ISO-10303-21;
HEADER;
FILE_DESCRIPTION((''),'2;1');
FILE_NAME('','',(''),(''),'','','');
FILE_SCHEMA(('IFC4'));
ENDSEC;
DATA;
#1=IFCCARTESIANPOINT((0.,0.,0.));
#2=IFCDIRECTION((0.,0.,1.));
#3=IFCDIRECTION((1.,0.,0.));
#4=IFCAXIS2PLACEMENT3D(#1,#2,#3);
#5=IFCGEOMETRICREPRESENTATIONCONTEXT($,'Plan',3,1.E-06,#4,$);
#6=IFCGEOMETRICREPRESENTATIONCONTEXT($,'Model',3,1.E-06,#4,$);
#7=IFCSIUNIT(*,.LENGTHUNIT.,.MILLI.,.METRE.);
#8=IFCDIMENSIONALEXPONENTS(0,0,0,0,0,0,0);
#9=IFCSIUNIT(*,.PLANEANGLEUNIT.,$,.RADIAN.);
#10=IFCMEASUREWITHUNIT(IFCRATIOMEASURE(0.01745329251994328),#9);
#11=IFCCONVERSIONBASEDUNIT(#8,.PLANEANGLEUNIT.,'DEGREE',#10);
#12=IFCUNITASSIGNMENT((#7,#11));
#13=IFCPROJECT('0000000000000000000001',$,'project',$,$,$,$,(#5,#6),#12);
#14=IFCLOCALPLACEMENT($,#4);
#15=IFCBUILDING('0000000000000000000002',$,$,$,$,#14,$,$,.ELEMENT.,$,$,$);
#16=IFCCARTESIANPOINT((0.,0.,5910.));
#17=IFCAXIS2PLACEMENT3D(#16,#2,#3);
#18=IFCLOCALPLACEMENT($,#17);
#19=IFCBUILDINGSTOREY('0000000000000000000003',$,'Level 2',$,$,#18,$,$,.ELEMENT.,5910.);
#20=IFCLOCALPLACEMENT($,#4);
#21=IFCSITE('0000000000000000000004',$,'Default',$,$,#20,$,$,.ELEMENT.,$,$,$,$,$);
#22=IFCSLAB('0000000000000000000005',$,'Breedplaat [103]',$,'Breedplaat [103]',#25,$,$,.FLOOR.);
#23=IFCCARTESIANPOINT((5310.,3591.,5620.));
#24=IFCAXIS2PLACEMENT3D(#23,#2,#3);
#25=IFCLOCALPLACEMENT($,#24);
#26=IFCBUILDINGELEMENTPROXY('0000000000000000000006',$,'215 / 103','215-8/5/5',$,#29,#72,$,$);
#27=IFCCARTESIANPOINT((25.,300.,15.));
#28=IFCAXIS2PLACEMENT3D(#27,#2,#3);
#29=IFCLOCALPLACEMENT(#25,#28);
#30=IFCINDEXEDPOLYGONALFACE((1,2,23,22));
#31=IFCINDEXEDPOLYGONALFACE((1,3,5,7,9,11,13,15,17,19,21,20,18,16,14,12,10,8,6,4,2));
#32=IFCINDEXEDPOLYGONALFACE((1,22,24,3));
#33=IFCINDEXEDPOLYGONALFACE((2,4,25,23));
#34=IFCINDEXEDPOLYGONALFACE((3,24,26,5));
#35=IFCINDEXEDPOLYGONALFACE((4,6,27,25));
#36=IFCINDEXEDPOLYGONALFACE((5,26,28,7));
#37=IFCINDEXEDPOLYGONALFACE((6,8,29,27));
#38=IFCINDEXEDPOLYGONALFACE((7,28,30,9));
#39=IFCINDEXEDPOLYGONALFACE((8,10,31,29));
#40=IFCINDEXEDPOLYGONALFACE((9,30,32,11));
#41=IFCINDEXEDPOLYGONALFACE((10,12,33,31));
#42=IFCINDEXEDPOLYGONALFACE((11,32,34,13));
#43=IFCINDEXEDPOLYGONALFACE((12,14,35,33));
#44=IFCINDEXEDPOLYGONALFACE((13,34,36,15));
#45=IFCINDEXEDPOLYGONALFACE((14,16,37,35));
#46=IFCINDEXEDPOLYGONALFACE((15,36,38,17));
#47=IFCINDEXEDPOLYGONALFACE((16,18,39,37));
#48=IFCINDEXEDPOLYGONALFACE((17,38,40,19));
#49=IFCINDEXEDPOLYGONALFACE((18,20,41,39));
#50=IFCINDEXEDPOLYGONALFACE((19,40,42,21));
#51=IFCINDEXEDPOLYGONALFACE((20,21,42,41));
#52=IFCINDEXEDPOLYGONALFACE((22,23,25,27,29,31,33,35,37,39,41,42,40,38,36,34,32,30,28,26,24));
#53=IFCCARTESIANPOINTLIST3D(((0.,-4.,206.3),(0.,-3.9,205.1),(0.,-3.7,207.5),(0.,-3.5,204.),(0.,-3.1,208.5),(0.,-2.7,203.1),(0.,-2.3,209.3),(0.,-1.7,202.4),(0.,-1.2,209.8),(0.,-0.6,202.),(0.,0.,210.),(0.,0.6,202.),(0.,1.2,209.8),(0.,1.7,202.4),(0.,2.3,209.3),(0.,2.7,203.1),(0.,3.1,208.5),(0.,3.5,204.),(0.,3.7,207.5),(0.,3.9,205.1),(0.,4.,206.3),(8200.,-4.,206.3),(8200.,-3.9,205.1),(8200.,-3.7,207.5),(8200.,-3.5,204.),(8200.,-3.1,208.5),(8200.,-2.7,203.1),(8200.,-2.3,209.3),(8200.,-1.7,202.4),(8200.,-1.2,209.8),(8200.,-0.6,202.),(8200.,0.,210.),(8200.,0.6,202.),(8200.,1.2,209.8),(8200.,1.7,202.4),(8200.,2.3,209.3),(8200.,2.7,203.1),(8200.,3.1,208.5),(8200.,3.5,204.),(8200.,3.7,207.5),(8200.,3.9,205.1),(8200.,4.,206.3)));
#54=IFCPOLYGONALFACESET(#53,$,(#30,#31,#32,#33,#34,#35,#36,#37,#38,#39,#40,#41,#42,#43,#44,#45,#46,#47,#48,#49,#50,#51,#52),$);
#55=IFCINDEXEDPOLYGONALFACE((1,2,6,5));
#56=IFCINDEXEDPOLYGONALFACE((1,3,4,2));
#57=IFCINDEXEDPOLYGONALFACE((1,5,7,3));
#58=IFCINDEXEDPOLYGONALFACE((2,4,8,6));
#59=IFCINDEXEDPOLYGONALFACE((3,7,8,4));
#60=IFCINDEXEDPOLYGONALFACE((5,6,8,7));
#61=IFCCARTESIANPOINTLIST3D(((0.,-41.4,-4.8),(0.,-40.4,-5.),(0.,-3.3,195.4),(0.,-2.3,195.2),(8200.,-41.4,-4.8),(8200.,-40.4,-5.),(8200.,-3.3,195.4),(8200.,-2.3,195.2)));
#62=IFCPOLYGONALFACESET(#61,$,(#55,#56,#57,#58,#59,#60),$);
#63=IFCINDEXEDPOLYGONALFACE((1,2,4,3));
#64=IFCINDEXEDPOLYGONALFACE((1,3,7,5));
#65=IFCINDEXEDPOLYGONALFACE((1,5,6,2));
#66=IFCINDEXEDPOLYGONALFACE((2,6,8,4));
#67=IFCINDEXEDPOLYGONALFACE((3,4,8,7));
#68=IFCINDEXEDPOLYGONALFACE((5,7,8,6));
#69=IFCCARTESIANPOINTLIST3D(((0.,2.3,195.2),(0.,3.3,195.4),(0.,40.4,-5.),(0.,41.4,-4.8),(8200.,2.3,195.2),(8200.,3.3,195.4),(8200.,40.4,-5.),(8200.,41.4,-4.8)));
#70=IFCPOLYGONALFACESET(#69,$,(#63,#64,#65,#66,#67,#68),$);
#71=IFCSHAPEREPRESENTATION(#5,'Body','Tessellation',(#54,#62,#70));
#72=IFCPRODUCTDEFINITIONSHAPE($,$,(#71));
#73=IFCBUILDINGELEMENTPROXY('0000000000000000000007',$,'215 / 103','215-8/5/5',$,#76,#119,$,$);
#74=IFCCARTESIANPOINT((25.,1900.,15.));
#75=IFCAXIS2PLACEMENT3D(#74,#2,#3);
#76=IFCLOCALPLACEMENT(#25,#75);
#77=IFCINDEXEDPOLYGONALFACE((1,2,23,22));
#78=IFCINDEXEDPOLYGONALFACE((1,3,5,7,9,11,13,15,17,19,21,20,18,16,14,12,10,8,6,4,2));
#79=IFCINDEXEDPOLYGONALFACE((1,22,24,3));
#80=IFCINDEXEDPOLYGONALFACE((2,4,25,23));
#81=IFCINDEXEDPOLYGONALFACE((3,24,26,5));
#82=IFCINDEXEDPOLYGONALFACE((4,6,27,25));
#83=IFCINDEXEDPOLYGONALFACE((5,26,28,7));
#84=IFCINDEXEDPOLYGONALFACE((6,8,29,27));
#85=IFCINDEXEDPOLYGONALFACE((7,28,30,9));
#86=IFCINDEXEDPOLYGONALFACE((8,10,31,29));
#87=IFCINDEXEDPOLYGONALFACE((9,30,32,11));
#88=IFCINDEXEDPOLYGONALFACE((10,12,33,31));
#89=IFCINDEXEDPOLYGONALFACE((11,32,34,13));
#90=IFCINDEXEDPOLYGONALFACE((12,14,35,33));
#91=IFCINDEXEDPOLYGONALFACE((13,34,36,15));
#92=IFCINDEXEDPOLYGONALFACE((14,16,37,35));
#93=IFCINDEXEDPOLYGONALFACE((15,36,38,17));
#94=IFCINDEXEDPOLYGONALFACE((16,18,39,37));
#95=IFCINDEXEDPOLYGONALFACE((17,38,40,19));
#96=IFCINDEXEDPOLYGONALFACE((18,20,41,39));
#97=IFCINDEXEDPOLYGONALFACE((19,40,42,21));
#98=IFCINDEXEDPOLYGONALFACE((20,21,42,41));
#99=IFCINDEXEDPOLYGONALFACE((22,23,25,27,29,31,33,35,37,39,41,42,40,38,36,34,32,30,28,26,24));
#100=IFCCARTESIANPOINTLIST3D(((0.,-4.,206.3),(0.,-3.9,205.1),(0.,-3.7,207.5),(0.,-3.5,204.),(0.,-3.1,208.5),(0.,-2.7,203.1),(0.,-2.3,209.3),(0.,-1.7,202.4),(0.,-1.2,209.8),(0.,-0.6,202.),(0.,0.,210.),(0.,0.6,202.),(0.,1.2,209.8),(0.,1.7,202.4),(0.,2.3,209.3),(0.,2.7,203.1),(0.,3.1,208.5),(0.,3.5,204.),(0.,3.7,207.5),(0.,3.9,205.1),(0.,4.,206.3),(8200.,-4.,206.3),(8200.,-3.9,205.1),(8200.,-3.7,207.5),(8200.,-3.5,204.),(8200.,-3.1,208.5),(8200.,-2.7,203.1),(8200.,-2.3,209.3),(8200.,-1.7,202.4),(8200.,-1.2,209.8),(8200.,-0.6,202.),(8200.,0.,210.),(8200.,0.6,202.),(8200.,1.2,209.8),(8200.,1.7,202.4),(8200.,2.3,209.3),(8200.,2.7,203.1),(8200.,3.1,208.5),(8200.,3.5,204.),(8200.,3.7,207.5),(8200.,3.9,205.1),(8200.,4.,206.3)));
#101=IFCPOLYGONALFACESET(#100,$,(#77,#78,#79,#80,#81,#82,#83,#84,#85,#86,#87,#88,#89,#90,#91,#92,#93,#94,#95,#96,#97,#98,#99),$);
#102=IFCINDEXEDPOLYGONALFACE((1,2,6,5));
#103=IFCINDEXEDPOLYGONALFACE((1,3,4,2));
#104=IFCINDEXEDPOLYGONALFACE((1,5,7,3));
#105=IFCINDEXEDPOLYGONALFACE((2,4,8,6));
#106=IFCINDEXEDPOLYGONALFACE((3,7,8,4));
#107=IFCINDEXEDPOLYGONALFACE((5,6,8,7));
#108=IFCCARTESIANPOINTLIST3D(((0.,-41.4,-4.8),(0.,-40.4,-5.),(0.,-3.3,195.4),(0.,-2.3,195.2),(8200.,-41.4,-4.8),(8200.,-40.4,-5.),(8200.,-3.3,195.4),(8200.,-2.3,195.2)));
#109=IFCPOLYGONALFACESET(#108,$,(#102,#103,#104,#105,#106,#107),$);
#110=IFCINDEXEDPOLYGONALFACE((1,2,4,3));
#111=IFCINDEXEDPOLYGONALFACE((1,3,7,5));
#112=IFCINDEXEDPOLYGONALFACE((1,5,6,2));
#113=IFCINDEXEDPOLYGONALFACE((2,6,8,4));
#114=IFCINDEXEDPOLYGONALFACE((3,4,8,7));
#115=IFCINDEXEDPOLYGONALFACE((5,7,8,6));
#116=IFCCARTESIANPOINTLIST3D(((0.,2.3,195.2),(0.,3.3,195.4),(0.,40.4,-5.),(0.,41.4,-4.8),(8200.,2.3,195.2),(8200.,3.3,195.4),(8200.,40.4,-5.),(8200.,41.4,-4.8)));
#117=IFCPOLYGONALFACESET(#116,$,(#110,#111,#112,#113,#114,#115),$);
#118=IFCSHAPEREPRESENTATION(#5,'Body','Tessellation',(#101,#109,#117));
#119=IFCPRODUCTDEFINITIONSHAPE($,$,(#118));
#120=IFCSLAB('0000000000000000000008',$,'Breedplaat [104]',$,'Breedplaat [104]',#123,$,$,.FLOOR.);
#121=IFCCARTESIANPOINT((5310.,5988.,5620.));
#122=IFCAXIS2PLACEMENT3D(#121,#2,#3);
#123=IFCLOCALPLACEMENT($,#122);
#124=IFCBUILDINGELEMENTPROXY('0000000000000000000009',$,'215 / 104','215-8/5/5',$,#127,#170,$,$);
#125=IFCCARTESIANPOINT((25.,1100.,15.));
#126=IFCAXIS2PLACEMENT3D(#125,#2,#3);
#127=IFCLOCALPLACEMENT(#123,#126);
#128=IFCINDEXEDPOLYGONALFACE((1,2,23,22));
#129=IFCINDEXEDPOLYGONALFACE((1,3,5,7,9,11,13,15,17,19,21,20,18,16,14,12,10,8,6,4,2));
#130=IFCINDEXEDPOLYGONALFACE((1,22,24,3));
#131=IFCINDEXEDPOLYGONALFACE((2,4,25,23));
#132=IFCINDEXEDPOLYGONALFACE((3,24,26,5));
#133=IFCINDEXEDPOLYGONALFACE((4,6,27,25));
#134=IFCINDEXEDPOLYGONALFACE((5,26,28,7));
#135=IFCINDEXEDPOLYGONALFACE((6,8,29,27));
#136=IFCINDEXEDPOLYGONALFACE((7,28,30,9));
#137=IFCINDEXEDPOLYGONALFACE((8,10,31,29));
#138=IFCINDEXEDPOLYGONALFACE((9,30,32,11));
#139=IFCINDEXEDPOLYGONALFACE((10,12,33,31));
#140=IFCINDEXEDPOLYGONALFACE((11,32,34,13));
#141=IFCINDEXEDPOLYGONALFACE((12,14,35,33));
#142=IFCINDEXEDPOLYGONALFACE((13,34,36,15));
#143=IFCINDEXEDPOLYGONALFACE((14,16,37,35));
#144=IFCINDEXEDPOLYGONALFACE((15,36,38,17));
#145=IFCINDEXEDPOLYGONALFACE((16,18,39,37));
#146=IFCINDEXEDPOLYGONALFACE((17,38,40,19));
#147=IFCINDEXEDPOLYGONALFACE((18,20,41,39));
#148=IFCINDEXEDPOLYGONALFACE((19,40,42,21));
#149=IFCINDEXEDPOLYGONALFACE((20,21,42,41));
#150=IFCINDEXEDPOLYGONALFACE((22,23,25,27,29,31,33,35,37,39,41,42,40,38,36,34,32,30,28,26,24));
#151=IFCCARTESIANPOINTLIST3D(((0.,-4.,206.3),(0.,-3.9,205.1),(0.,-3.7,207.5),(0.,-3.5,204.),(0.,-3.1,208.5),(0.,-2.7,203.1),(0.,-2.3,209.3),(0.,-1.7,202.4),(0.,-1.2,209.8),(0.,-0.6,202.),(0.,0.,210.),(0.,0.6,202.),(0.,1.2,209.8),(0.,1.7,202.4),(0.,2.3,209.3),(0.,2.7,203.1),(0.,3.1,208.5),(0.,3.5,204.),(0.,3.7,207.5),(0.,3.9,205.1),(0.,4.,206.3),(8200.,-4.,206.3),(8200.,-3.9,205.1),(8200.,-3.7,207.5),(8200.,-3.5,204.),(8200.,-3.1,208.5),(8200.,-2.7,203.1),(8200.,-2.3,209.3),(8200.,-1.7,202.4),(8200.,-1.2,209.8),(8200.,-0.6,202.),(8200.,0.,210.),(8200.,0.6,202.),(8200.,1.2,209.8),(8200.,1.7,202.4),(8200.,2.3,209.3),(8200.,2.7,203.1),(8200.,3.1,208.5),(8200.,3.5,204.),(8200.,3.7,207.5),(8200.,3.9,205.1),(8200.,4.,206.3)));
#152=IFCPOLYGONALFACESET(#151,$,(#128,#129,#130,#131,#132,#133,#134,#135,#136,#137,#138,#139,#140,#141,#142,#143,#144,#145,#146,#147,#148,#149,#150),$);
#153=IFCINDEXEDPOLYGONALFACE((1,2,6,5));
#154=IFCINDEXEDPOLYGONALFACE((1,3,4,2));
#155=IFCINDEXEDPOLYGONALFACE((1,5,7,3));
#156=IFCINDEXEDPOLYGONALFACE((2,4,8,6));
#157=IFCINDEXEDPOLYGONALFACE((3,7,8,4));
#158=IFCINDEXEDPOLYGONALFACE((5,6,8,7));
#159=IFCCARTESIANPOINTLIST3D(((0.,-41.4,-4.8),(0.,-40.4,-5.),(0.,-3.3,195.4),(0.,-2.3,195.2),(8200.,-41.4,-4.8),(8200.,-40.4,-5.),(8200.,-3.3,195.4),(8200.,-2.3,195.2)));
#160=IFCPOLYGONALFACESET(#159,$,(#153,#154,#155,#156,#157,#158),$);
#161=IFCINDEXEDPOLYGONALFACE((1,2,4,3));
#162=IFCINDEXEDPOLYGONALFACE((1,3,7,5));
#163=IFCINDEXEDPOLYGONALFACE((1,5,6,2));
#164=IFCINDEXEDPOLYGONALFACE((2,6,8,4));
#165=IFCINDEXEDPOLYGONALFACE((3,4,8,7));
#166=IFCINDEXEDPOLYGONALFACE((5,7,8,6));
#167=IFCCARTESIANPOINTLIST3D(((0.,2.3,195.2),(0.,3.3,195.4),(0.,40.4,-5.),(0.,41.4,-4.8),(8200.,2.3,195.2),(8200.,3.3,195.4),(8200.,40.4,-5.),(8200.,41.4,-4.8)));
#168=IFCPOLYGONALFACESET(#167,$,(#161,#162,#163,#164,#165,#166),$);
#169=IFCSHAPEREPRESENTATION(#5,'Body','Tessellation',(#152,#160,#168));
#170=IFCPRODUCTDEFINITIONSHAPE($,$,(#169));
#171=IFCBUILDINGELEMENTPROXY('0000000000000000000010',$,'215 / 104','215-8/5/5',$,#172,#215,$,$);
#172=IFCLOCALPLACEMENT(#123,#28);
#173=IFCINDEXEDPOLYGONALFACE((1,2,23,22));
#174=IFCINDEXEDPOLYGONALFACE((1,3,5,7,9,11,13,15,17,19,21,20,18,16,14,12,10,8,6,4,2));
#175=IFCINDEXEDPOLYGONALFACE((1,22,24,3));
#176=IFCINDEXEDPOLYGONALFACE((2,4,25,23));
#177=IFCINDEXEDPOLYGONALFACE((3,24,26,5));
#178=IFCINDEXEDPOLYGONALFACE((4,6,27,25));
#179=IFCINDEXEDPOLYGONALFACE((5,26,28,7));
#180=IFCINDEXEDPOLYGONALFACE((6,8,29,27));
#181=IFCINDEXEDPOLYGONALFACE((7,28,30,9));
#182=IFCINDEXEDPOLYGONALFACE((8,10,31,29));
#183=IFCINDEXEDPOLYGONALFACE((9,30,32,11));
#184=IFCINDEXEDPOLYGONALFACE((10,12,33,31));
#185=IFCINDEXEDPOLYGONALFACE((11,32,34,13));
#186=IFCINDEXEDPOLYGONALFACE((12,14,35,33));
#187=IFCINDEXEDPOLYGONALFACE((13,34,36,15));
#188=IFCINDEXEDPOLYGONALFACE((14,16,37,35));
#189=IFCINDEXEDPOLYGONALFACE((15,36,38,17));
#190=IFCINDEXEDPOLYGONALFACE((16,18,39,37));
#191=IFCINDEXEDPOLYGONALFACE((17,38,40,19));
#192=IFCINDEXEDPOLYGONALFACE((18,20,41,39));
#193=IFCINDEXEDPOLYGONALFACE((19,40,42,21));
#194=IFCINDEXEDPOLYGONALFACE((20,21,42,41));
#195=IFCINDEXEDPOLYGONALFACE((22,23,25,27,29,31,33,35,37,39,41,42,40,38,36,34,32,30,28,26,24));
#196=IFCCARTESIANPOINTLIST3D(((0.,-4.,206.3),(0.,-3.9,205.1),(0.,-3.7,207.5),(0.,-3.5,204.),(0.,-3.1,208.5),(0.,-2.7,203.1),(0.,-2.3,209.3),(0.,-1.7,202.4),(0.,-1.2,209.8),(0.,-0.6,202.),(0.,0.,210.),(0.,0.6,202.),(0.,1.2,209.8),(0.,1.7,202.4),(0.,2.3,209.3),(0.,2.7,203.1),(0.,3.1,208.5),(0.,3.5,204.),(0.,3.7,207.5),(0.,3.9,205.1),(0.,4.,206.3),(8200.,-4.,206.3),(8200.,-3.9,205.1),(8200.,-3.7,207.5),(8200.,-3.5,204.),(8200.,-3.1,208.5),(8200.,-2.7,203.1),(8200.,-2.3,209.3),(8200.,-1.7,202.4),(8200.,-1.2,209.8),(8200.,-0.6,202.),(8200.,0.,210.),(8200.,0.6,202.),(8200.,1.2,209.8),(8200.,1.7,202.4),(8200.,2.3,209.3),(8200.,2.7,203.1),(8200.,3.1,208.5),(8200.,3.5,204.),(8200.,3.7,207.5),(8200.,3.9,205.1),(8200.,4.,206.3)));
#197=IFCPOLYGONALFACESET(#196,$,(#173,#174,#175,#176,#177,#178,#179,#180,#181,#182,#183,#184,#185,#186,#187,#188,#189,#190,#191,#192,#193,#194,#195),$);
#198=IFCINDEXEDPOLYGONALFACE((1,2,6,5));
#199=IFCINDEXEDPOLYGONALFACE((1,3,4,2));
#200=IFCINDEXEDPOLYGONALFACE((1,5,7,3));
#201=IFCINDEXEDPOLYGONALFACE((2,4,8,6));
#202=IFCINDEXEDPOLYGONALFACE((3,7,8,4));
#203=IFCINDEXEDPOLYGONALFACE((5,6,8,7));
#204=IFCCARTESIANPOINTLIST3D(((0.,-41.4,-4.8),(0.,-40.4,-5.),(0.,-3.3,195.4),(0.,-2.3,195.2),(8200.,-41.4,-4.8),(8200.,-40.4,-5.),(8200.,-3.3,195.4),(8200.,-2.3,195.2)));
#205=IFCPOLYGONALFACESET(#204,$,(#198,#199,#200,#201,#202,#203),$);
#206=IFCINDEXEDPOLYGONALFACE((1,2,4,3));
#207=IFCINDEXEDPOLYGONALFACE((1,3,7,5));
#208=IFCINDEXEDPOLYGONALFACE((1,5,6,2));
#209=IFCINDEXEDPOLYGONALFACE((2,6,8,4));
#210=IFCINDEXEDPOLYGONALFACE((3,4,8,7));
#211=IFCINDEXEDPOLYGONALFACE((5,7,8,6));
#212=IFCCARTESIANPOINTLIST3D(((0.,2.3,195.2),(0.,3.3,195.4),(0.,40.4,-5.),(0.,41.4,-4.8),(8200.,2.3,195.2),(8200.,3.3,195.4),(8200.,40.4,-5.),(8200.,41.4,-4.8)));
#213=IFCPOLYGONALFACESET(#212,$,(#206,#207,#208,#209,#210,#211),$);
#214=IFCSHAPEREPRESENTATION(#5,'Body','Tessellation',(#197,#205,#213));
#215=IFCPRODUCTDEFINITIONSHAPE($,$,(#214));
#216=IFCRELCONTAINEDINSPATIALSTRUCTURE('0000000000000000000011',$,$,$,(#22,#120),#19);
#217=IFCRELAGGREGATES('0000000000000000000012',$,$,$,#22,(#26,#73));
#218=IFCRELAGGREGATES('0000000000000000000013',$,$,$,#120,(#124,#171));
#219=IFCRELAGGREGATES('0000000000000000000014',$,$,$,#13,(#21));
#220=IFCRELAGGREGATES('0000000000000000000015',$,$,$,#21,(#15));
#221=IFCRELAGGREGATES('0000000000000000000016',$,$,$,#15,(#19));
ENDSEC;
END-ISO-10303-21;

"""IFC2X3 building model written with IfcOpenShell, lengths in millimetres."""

from ifc_helpers import new_model, entity, si_unit, converted_unit, frame, origin_with_axes, origin_2d_with_axis, place, context, project, spatial, rectangle, circle, extrude, element, aggregate, save


model = new_model("IFC2X3")

# Units and contexts
plan_context = context("Plan", 3, precision=1e-06, world=origin_with_axes())
model_context = context("Model", 3, precision=1e-06, world=origin_with_axes())
ifc_project = project(units=[si_unit("LENGTHUNIT", "METRE", prefix="MILLI"), converted_unit("PLANEANGLEUNIT", "DEGREE", entity("IfcRatioMeasure", 0.01745329251994328), si_unit("PLANEANGLEUNIT", "RADIAN"), dimensions=[0, 0, 0, 0, 0, 0, 0])], contexts=[plan_context, model_context])

# Site, building, storey
site_placement = place(None, origin_with_axes())
site = spatial("IfcSite", under=ifc_project, at=site_placement, Name="Default", CompositionType="ELEMENT")
building_placement = place(None, origin_with_axes())
building = spatial("IfcBuilding", under=site, at=building_placement, CompositionType="ELEMENT")
storey_placement = place(None, frame((0.0, 0.0, 5910.0), z_axis=(0.0, 0.0, 1.0), x_axis=(1.0, 0.0, 0.0)))
storey = spatial("IfcBuildingStorey", under=building, at=storey_placement, Name="Level 2", CompositionType="ELEMENT", Elevation=5910.0)

# Slabs, building element proxies
slab_1_placement = place(None, frame((5310.0, 3591.0, 5620.0), z_axis=(0.0, 0.0, 1.0), x_axis=(1.0, 0.0, 0.0)))
slab_1 = element("IfcSlab", 1, at=slab_1_placement, inside=storey, Name="Breedplaat [103]", ObjectType="Breedplaat [103]", PredefinedType="FLOOR")
proxy_1_placement = place(slab_1_placement, frame((25.0, 300.0, 15.0), z_axis=(0.0, 0.0, 1.0), x_axis=(1.0, 0.0, 0.0)))
proxy_1 = element("IfcBuildingElementProxy", 2, at=proxy_1_placement, Name="215 / 103", Description="215-8/5/5", context=plan_context, shape_type="SweptSolid", body=[
    extrude(circle(Radius=4.0, at=origin_2d_with_axis()), frame((0.0, 0.0, 206.0), z_axis=(1.0, 0.0, 0.0), x_axis=(0.0, 0.0, 1.0)), (0.0, 0.0, 1.0), 8200.0),
    extrude(rectangle(XDim=203.8, YDim=1.0, at=origin_2d_with_axis()), frame((0.0, -21.9, 95.2), z_axis=(1.0, 0.0, 0.0), x_axis=(0.0, 0.187112, 0.982339)), (0.0, 0.0, 1.0), 8200.0),
    extrude(rectangle(XDim=203.8, YDim=1.0, at=origin_2d_with_axis()), frame((0.0, 21.9, 95.2), z_axis=(1.0, 0.0, 0.0), x_axis=(0.0, -0.187112, 0.982339)), (0.0, 0.0, 1.0), 8200.0),
])
proxy_2_placement = place(slab_1_placement, frame((25.0, 1900.0, 15.0), z_axis=(0.0, 0.0, 1.0), x_axis=(1.0, 0.0, 0.0)))
proxy_2 = element("IfcBuildingElementProxy", 3, at=proxy_2_placement, Name="215 / 103", Description="215-8/5/5", context=plan_context, shape_type="SweptSolid", body=[
    extrude(circle(Radius=4.0, at=origin_2d_with_axis()), frame((0.0, 0.0, 206.0), z_axis=(1.0, 0.0, 0.0), x_axis=(0.0, 0.0, 1.0)), (0.0, 0.0, 1.0), 8200.0),
    extrude(rectangle(XDim=203.8, YDim=1.0, at=origin_2d_with_axis()), frame((0.0, -21.9, 95.2), z_axis=(1.0, 0.0, 0.0), x_axis=(0.0, 0.187112, 0.982339)), (0.0, 0.0, 1.0), 8200.0),
    extrude(rectangle(XDim=203.8, YDim=1.0, at=origin_2d_with_axis()), frame((0.0, 21.9, 95.2), z_axis=(1.0, 0.0, 0.0), x_axis=(0.0, -0.187112, 0.982339)), (0.0, 0.0, 1.0), 8200.0),
])
aggregate(slab_1, [proxy_1, proxy_2])
slab_2_placement = place(None, frame((5310.0, 5988.0, 5620.0), z_axis=(0.0, 0.0, 1.0), x_axis=(1.0, 0.0, 0.0)))
slab_2 = element("IfcSlab", 4, at=slab_2_placement, inside=storey, Name="Breedplaat [104]", ObjectType="Breedplaat [104]", PredefinedType="FLOOR")
proxy_3_placement = place(slab_2_placement, frame((25.0, 1100.0, 15.0), z_axis=(0.0, 0.0, 1.0), x_axis=(1.0, 0.0, 0.0)))
proxy_3 = element("IfcBuildingElementProxy", 5, at=proxy_3_placement, Name="215 / 104", Description="215-8/5/5", context=plan_context, shape_type="SweptSolid", body=[
    extrude(circle(Radius=4.0, at=origin_2d_with_axis()), frame((0.0, 0.0, 206.0), z_axis=(1.0, 0.0, 0.0), x_axis=(0.0, 0.0, 1.0)), (0.0, 0.0, 1.0), 8200.0),
    extrude(rectangle(XDim=203.8, YDim=1.0, at=origin_2d_with_axis()), frame((0.0, -21.9, 95.2), z_axis=(1.0, 0.0, 0.0), x_axis=(0.0, 0.187112, 0.982339)), (0.0, 0.0, 1.0), 8200.0),
    extrude(rectangle(XDim=203.8, YDim=1.0, at=origin_2d_with_axis()), frame((0.0, 21.9, 95.2), z_axis=(1.0, 0.0, 0.0), x_axis=(0.0, -0.187112, 0.982339)), (0.0, 0.0, 1.0), 8200.0),
])
proxy_4_placement = place(slab_2_placement, frame((25.0, 300.0, 15.0), z_axis=(0.0, 0.0, 1.0), x_axis=(1.0, 0.0, 0.0)))
proxy_4 = element("IfcBuildingElementProxy", 6, at=proxy_4_placement, Name="215 / 104", Description="215-8/5/5", context=plan_context, shape_type="SweptSolid", body=[
    extrude(circle(Radius=4.0, at=origin_2d_with_axis()), frame((0.0, 0.0, 206.0), z_axis=(1.0, 0.0, 0.0), x_axis=(0.0, 0.0, 1.0)), (0.0, 0.0, 1.0), 8200.0),
    extrude(rectangle(XDim=203.8, YDim=1.0, at=origin_2d_with_axis()), frame((0.0, -21.9, 95.2), z_axis=(1.0, 0.0, 0.0), x_axis=(0.0, 0.187112, 0.982339)), (0.0, 0.0, 1.0), 8200.0),
    extrude(rectangle(XDim=203.8, YDim=1.0, at=origin_2d_with_axis()), frame((0.0, 21.9, 95.2), z_axis=(1.0, 0.0, 0.0), x_axis=(0.0, -0.187112, 0.982339)), (0.0, 0.0, 1.0), 8200.0),
])
aggregate(slab_2, [proxy_3, proxy_4])

save(model, "model.ifc")
